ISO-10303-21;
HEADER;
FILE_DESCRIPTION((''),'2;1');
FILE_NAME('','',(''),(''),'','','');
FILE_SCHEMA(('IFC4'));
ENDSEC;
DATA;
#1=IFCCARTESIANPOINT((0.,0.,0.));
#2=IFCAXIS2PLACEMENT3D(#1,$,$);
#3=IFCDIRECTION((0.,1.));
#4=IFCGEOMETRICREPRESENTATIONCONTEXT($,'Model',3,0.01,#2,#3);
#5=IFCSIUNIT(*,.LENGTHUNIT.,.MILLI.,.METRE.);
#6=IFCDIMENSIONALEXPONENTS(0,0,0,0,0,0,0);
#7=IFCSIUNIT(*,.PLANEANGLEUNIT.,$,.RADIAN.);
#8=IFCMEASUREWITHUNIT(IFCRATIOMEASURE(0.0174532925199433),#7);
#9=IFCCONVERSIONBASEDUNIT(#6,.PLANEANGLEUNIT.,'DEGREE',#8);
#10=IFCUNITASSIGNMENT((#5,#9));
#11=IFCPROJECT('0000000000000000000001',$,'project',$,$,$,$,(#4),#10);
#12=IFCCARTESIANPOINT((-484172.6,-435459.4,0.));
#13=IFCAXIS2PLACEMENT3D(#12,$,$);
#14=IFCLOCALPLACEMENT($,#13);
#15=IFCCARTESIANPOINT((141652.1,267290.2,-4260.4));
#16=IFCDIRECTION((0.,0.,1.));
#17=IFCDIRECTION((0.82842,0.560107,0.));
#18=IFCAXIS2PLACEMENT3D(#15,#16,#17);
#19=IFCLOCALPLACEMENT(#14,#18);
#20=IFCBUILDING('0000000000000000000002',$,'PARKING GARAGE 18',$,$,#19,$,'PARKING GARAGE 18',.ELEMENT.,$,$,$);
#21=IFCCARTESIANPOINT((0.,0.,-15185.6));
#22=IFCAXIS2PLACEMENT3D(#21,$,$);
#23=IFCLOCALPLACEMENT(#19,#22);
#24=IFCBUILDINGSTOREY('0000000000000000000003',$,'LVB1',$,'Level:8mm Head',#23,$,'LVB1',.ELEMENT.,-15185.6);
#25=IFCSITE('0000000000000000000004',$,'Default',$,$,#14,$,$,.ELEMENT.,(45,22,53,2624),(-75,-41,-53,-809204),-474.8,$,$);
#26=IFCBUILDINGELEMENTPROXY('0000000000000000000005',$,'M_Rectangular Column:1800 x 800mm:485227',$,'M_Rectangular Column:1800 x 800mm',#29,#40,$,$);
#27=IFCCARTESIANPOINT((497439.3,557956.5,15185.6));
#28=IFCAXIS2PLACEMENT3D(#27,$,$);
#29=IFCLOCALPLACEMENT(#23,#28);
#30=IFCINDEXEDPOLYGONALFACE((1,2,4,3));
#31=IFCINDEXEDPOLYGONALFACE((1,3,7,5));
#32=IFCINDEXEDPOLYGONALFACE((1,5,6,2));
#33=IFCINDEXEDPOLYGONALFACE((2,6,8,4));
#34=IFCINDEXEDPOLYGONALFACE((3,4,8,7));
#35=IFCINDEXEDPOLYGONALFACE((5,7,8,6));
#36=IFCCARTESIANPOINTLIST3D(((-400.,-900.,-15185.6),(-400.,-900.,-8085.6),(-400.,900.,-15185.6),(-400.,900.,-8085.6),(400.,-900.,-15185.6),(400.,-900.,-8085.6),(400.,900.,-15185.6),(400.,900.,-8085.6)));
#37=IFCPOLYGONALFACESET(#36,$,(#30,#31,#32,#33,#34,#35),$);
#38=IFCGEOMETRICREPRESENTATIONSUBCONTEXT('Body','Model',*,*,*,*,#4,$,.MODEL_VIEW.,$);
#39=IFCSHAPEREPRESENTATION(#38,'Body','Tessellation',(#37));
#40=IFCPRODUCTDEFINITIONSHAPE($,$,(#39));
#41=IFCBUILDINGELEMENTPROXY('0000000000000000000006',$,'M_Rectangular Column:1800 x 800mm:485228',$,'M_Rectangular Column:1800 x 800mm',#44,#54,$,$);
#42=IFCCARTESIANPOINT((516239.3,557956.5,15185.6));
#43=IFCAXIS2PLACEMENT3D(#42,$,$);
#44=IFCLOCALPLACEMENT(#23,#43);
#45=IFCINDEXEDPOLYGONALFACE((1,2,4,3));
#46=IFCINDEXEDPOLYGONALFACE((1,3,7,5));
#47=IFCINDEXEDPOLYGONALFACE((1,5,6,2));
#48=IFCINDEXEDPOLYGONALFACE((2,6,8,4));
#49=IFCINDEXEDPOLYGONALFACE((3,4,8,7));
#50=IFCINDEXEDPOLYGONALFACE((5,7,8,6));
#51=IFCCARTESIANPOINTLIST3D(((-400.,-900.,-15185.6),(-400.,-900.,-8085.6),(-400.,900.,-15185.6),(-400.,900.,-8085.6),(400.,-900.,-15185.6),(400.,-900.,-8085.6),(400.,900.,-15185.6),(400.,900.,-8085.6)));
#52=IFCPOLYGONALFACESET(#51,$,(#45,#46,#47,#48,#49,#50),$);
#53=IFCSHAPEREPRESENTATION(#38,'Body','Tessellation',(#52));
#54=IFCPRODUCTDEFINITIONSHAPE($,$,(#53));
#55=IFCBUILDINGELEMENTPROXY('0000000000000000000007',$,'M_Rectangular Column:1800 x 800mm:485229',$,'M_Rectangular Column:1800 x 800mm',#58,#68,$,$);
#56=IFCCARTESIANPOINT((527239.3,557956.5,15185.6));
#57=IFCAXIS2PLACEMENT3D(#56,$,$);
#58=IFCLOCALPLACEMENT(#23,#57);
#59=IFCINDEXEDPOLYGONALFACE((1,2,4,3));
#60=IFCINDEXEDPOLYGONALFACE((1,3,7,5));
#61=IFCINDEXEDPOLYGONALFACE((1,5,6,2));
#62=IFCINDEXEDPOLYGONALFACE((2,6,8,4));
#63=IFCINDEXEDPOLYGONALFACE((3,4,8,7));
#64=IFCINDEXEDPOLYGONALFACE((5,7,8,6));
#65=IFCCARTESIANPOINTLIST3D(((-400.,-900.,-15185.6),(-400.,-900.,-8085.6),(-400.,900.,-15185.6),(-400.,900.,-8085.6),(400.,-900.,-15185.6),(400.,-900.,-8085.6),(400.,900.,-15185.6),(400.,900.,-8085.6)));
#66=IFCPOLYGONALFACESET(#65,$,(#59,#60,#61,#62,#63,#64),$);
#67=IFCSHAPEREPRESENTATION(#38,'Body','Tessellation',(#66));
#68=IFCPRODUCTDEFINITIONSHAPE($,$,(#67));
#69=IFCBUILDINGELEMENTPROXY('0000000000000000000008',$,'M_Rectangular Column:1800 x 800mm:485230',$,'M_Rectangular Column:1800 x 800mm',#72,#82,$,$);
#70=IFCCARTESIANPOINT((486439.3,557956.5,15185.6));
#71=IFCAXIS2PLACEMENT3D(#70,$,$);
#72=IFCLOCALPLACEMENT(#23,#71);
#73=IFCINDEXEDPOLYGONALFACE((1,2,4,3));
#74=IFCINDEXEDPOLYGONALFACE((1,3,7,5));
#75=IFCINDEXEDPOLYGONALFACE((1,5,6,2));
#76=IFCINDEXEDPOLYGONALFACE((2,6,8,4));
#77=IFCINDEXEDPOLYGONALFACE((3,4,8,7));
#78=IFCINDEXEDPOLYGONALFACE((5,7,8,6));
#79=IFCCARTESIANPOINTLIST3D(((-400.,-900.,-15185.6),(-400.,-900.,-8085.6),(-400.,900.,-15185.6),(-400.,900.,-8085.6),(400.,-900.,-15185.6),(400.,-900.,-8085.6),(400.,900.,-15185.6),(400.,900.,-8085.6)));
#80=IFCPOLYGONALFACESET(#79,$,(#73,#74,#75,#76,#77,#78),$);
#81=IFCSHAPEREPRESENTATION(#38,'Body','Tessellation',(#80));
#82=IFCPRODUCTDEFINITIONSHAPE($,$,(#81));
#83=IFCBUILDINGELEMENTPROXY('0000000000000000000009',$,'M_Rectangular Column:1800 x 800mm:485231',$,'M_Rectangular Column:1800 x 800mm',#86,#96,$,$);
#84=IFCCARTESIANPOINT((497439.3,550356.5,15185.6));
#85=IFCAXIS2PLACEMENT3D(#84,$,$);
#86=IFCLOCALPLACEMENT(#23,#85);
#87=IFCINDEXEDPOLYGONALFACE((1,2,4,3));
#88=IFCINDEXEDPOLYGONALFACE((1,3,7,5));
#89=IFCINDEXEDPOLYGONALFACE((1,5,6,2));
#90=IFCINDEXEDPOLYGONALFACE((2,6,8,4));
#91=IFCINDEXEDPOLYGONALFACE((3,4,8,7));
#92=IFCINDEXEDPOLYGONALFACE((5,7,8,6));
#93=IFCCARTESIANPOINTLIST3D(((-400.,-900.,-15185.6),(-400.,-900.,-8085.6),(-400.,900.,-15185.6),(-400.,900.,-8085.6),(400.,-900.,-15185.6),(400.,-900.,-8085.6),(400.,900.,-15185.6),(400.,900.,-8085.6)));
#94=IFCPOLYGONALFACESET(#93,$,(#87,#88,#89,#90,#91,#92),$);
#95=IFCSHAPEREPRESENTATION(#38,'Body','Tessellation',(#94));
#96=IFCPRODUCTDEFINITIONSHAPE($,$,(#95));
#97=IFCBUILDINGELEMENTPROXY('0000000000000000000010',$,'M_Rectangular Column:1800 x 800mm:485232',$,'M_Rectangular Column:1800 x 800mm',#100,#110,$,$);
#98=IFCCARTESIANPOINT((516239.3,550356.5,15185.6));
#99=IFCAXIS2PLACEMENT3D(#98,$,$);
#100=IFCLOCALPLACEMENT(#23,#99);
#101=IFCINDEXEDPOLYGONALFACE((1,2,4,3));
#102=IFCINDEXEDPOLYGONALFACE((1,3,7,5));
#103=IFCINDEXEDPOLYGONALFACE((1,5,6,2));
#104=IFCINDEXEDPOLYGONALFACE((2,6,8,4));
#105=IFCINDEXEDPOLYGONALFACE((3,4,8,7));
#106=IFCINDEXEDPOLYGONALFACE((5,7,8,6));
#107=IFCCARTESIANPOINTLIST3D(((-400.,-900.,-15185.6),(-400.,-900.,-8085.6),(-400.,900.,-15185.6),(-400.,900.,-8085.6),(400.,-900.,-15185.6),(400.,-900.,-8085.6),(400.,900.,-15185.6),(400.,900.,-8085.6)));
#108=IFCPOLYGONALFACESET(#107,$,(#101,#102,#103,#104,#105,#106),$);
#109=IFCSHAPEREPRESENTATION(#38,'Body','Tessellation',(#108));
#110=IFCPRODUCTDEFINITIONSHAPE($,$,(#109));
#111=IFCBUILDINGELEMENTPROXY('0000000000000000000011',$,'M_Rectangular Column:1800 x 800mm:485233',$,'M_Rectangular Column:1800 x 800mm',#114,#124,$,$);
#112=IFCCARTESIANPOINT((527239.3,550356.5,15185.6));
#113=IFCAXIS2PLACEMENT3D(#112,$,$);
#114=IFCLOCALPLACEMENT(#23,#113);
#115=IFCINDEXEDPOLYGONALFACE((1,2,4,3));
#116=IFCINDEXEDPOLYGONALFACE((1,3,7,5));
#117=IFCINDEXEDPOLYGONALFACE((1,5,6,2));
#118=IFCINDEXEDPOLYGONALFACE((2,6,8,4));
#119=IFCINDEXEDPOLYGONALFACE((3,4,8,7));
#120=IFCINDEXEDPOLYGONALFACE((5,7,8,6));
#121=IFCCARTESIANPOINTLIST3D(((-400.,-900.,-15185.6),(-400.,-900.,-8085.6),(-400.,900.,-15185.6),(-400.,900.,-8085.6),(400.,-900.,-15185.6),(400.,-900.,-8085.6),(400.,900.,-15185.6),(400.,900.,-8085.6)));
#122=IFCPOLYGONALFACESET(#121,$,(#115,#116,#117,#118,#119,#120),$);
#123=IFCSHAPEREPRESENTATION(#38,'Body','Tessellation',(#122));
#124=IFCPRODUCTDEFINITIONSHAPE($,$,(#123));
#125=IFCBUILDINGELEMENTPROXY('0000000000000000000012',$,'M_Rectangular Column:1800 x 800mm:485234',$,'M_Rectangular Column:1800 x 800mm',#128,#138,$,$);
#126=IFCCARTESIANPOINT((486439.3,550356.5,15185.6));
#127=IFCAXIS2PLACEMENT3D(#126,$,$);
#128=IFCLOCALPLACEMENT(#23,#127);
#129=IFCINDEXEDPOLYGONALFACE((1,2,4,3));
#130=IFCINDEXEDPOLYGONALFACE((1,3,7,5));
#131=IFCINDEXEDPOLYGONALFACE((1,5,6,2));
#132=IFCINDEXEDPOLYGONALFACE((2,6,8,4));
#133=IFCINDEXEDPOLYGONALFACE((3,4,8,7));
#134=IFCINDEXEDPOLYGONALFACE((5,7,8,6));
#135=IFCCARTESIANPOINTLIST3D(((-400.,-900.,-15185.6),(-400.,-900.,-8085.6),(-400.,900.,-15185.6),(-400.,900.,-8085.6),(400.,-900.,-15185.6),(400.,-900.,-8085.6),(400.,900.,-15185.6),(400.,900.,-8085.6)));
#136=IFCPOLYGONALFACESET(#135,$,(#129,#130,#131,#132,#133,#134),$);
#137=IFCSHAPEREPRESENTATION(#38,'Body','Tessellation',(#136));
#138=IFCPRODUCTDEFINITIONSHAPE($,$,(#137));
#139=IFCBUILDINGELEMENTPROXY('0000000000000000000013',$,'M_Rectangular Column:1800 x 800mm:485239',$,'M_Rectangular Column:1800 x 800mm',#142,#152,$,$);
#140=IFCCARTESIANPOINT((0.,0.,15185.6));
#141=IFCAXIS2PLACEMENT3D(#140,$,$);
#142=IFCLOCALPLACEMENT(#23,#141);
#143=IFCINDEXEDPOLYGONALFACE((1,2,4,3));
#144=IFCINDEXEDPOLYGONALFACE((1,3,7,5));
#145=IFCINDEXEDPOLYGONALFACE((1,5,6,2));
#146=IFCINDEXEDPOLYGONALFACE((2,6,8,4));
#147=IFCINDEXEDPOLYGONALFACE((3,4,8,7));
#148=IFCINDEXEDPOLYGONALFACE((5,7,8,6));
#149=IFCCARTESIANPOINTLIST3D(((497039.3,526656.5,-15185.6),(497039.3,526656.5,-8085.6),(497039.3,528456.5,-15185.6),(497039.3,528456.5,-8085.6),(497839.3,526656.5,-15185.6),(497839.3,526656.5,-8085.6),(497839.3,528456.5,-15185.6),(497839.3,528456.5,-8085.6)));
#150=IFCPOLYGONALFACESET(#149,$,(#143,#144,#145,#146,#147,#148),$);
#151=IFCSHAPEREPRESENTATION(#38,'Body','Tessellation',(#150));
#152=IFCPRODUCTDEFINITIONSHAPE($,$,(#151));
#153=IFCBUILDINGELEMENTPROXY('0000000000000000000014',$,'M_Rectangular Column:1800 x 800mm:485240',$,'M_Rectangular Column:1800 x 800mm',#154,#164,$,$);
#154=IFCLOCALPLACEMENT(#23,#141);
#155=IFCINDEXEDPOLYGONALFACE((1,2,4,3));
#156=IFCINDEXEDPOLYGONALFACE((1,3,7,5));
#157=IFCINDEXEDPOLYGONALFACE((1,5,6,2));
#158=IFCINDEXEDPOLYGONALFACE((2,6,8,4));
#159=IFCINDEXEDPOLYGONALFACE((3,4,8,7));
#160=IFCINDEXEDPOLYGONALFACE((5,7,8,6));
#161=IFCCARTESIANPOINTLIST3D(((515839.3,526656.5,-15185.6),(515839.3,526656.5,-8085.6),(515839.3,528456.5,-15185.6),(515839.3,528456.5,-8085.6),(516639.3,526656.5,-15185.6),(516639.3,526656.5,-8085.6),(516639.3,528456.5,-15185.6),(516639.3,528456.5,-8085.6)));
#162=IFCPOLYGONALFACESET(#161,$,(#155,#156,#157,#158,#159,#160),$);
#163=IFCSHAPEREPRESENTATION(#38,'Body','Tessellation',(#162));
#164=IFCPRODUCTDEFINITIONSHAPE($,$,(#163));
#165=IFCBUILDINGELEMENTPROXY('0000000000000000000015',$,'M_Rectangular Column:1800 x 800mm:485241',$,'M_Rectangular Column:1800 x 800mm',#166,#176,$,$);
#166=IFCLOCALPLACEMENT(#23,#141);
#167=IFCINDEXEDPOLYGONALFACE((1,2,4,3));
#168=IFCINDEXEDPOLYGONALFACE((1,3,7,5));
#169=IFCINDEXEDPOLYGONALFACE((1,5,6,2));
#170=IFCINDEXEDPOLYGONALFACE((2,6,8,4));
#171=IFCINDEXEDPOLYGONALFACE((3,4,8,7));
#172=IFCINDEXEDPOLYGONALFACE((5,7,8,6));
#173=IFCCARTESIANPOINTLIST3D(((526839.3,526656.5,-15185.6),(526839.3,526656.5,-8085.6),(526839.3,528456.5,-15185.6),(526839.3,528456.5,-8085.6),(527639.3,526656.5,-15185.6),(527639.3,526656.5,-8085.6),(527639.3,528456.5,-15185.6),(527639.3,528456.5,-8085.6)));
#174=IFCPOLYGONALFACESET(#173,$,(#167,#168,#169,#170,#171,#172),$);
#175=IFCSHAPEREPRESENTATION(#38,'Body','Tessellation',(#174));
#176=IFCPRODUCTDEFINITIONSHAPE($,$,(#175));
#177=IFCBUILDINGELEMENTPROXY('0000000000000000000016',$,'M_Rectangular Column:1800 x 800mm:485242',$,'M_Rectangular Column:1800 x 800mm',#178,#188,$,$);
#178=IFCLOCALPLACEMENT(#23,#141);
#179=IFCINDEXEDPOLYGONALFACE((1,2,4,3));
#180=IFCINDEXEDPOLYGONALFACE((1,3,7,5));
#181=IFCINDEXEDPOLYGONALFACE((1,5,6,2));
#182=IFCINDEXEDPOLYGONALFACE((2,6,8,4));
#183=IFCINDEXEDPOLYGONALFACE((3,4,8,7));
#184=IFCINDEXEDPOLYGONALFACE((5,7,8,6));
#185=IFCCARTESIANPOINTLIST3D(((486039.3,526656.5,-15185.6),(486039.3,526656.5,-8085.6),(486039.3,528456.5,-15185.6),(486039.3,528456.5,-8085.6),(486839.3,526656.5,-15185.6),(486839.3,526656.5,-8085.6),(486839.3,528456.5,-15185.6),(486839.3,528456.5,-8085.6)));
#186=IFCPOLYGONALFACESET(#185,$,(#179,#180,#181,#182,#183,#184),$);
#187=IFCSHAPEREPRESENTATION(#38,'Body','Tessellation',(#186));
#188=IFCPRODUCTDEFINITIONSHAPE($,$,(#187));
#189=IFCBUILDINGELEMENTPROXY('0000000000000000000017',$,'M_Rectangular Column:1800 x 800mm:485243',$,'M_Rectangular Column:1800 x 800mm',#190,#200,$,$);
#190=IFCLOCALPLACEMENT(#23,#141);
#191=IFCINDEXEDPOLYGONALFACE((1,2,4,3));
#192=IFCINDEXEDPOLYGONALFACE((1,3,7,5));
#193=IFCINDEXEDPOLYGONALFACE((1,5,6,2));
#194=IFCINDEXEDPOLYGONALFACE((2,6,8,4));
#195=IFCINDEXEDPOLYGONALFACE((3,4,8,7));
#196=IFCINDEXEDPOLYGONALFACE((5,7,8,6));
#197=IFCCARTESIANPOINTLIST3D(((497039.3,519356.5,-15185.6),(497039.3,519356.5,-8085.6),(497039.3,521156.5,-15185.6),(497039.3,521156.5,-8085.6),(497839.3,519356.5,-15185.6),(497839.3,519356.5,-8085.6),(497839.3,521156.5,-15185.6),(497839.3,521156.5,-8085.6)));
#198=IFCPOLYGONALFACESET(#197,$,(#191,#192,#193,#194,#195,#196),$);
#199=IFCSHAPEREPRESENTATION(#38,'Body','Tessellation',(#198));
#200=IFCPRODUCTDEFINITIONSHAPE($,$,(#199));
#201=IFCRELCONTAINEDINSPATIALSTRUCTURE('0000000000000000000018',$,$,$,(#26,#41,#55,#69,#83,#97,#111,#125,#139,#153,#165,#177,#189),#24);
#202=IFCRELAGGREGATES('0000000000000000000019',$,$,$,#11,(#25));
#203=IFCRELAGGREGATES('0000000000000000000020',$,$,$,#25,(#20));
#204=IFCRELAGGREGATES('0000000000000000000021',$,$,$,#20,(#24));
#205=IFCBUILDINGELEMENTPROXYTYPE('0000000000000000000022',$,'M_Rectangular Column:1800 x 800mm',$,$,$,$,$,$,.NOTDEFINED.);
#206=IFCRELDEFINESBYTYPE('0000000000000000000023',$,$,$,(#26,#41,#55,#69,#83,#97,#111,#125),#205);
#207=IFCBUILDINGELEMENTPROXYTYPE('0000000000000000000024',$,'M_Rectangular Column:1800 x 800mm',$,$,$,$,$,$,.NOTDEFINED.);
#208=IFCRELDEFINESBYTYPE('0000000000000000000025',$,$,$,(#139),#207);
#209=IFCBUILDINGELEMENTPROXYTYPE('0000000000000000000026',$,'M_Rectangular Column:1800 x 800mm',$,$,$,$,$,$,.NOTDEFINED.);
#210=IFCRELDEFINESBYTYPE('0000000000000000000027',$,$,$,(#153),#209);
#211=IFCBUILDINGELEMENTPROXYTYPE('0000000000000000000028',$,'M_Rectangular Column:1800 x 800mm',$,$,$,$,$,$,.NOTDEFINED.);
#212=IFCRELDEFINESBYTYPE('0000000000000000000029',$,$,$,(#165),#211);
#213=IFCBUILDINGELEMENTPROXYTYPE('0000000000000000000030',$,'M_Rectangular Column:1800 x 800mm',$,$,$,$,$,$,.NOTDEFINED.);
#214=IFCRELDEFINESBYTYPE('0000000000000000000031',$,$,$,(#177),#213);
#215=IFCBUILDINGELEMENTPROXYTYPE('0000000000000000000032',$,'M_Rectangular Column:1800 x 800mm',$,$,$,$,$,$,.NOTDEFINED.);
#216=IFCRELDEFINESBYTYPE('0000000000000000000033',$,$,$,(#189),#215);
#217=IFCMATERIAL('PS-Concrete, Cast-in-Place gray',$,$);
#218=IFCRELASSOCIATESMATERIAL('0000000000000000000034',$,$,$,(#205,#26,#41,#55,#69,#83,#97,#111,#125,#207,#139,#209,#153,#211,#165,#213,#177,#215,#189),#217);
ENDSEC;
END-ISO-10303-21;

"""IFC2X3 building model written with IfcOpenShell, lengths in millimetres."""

from ifc_helpers import new_model, entity, si_unit, converted_unit, direction, frame, frame_2d, origin, origin_2d_with_axis, place, context, subcontext, project, spatial, rectangle, extrude, source, transform, mapped, material, type_object, type_shapes, element, save


model = new_model("IFC2X3")

# Units and contexts
model_context = context("Model", 3, precision=0.01, world=origin(), true_north=direction((0.0, 1.0)))
body_context = subcontext(model_context, "Body", "Model", "MODEL_VIEW")
ifc_project = project(units=[si_unit("LENGTHUNIT", "METRE", prefix="MILLI"), converted_unit("PLANEANGLEUNIT", "DEGREE", entity("IfcRatioMeasure", 0.0174532925199433), si_unit("PLANEANGLEUNIT", "RADIAN"), dimensions=[0, 0, 0, 0, 0, 0, 0])], contexts=[model_context])

# Site, building, storey
site_placement = place(None, frame((-484172.6, -435459.4, 0.0)))
site = spatial("IfcSite", under=ifc_project, at=site_placement, Name="Default", CompositionType="ELEMENT", RefLatitude=(45, 22, 53, 2624), RefLongitude=(-75, -41, -53, -809204), RefElevation=-474.8)
building_placement = place(site_placement, frame((141652.1, 267290.2, -4260.4), z_axis=(0.0, 0.0, 1.0), x_axis=(0.82842, 0.560107, 0.0)))
building = spatial("IfcBuilding", under=site, at=building_placement, Name="PARKING GARAGE 18", LongName="PARKING GARAGE 18", CompositionType="ELEMENT")
storey_placement = place(building_placement, frame((0.0, 0.0, -15185.6)))
storey = spatial("IfcBuildingStorey", under=building, at=storey_placement, Name="LVB1", ObjectType="Level:8mm Head", LongName="LVB1", CompositionType="ELEMENT", Elevation=-15185.6)

# Building element proxies
ifc_material = material(Name="PS-Concrete, Cast-in-Place gray")
building_element_proxy_type_1 = type_object("IfcBuildingElementProxyType", Name="M_Rectangular Column:1800 x 800mm", PredefinedType="NOTDEFINED", material=ifc_material)
shared_shape_1 = source(origin(), body_context, "Body", "SweptSolid", [
    extrude(rectangle(XDim=1800.0, YDim=800.0, at=origin_2d_with_axis()), frame((0.0, 0.0, -15185.6), z_axis=(0.0, 0.0, 1.0), x_axis=(0.0, 1.0, 0.0)), (0.0, 0.0, 1.0), 7100.0),
])
type_shapes(building_element_proxy_type_1, [shared_shape_1])
for number, where, name in (
    (1, (497439.3, 557956.5, 15185.6), "M_Rectangular Column:1800 x 800mm:485227"),
    (2, (516239.3, 557956.5, 15185.6), "M_Rectangular Column:1800 x 800mm:485228"),
    (3, (527239.3, 557956.5, 15185.6), "M_Rectangular Column:1800 x 800mm:485229"),
    (4, (486439.3, 557956.5, 15185.6), "M_Rectangular Column:1800 x 800mm:485230"),
    (5, (497439.3, 550356.5, 15185.6), "M_Rectangular Column:1800 x 800mm:485231"),
    (6, (516239.3, 550356.5, 15185.6), "M_Rectangular Column:1800 x 800mm:485232"),
    (7, (527239.3, 550356.5, 15185.6), "M_Rectangular Column:1800 x 800mm:485233"),
    (8, (486439.3, 550356.5, 15185.6), "M_Rectangular Column:1800 x 800mm:485234"),
):
    element("IfcBuildingElementProxy", number, at=place(storey_placement, frame(where)), inside=storey, type_object=building_element_proxy_type_1, material=ifc_material, Name=name, ObjectType="M_Rectangular Column:1800 x 800mm", context=body_context, shape_type="MappedRepresentation", body=[
        mapped(shared_shape_1, transform((0.0, 0.0, 0.0), scale=1.0)),
    ])
building_element_proxy_type_2 = type_object("IfcBuildingElementProxyType", Name="M_Rectangular Column:1800 x 800mm", PredefinedType="NOTDEFINED", material=ifc_material)
shared_shape_2 = source(origin(), body_context, "Body", "SweptSolid", [
    extrude(rectangle(XDim=800.0, YDim=1800.0, at=frame_2d((0.0, 0.0), x_axis=(1.0, 0.0))), frame((497439.3, 527556.5, -15185.6), z_axis=(0.0, 0.0, 1.0), x_axis=(-1.0, 0.0, 0.0)), (0.0, 0.0, 1.0), 7100.0),
])
type_shapes(building_element_proxy_type_2, [shared_shape_2])
proxy_1_placement = place(storey_placement, frame((0.0, 0.0, 15185.6)))
element("IfcBuildingElementProxy", 9, at=proxy_1_placement, inside=storey, type_object=building_element_proxy_type_2, material=ifc_material, Name="M_Rectangular Column:1800 x 800mm:485239", ObjectType="M_Rectangular Column:1800 x 800mm", context=body_context, shape_type="MappedRepresentation", body=[
    mapped(shared_shape_2, transform((0.0, 0.0, 0.0), scale=1.0)),
])
building_element_proxy_type_3 = type_object("IfcBuildingElementProxyType", Name="M_Rectangular Column:1800 x 800mm", PredefinedType="NOTDEFINED", material=ifc_material)
shared_shape_3 = source(origin(), body_context, "Body", "SweptSolid", [
    extrude(rectangle(XDim=800.0, YDim=1800.0, at=frame_2d((0.0, 0.0), x_axis=(1.0, 0.0))), frame((516239.3, 527556.5, -15185.6), z_axis=(0.0, 0.0, 1.0), x_axis=(-1.0, 0.0, 0.0)), (0.0, 0.0, 1.0), 7100.0),
])
type_shapes(building_element_proxy_type_3, [shared_shape_3])
proxy_2_placement = place(storey_placement, frame((0.0, 0.0, 15185.6)))
element("IfcBuildingElementProxy", 10, at=proxy_2_placement, inside=storey, type_object=building_element_proxy_type_3, material=ifc_material, Name="M_Rectangular Column:1800 x 800mm:485240", ObjectType="M_Rectangular Column:1800 x 800mm", context=body_context, shape_type="MappedRepresentation", body=[
    mapped(shared_shape_3, transform((0.0, 0.0, 0.0), scale=1.0)),
])
building_element_proxy_type_4 = type_object("IfcBuildingElementProxyType", Name="M_Rectangular Column:1800 x 800mm", PredefinedType="NOTDEFINED", material=ifc_material)
shared_shape_4 = source(origin(), body_context, "Body", "SweptSolid", [
    extrude(rectangle(XDim=800.0, YDim=1800.0, at=frame_2d((0.0, 0.0), x_axis=(1.0, 0.0))), frame((527239.3, 527556.5, -15185.6), z_axis=(0.0, 0.0, 1.0), x_axis=(-1.0, 0.0, 0.0)), (0.0, 0.0, 1.0), 7100.0),
])
type_shapes(building_element_proxy_type_4, [shared_shape_4])
proxy_3_placement = place(storey_placement, frame((0.0, 0.0, 15185.6)))
element("IfcBuildingElementProxy", 11, at=proxy_3_placement, inside=storey, type_object=building_element_proxy_type_4, material=ifc_material, Name="M_Rectangular Column:1800 x 800mm:485241", ObjectType="M_Rectangular Column:1800 x 800mm", context=body_context, shape_type="MappedRepresentation", body=[
    mapped(shared_shape_4, transform((0.0, 0.0, 0.0), scale=1.0)),
])
building_element_proxy_type_5 = type_object("IfcBuildingElementProxyType", Name="M_Rectangular Column:1800 x 800mm", PredefinedType="NOTDEFINED", material=ifc_material)
shared_shape_5 = source(origin(), body_context, "Body", "SweptSolid", [
    extrude(rectangle(XDim=800.0, YDim=1800.0, at=frame_2d((0.0, 0.0), x_axis=(1.0, 0.0))), frame((486439.3, 527556.5, -15185.6), z_axis=(0.0, 0.0, 1.0), x_axis=(-1.0, 0.0, 0.0)), (0.0, 0.0, 1.0), 7100.0),
])
type_shapes(building_element_proxy_type_5, [shared_shape_5])
proxy_4_placement = place(storey_placement, frame((0.0, 0.0, 15185.6)))
element("IfcBuildingElementProxy", 12, at=proxy_4_placement, inside=storey, type_object=building_element_proxy_type_5, material=ifc_material, Name="M_Rectangular Column:1800 x 800mm:485242", ObjectType="M_Rectangular Column:1800 x 800mm", context=body_context, shape_type="MappedRepresentation", body=[
    mapped(shared_shape_5, transform((0.0, 0.0, 0.0), scale=1.0)),
])
building_element_proxy_type_6 = type_object("IfcBuildingElementProxyType", Name="M_Rectangular Column:1800 x 800mm", PredefinedType="NOTDEFINED", material=ifc_material)
shared_shape_6 = source(origin(), body_context, "Body", "SweptSolid", [
    extrude(rectangle(XDim=800.0, YDim=1800.0, at=frame_2d((0.0, 0.0), x_axis=(1.0, 0.0))), frame((497439.3, 520256.5, -15185.6), z_axis=(0.0, 0.0, 1.0), x_axis=(-1.0, 0.0, 0.0)), (0.0, 0.0, 1.0), 7100.0),
])
type_shapes(building_element_proxy_type_6, [shared_shape_6])
proxy_5_placement = place(storey_placement, frame((0.0, 0.0, 15185.6)))
element("IfcBuildingElementProxy", 13, at=proxy_5_placement, inside=storey, type_object=building_element_proxy_type_6, material=ifc_material, Name="M_Rectangular Column:1800 x 800mm:485243", ObjectType="M_Rectangular Column:1800 x 800mm", context=body_context, shape_type="MappedRepresentation", body=[
    mapped(shared_shape_6, transform((0.0, 0.0, 0.0), scale=1.0)),
])

save(model, "model.ifc")
